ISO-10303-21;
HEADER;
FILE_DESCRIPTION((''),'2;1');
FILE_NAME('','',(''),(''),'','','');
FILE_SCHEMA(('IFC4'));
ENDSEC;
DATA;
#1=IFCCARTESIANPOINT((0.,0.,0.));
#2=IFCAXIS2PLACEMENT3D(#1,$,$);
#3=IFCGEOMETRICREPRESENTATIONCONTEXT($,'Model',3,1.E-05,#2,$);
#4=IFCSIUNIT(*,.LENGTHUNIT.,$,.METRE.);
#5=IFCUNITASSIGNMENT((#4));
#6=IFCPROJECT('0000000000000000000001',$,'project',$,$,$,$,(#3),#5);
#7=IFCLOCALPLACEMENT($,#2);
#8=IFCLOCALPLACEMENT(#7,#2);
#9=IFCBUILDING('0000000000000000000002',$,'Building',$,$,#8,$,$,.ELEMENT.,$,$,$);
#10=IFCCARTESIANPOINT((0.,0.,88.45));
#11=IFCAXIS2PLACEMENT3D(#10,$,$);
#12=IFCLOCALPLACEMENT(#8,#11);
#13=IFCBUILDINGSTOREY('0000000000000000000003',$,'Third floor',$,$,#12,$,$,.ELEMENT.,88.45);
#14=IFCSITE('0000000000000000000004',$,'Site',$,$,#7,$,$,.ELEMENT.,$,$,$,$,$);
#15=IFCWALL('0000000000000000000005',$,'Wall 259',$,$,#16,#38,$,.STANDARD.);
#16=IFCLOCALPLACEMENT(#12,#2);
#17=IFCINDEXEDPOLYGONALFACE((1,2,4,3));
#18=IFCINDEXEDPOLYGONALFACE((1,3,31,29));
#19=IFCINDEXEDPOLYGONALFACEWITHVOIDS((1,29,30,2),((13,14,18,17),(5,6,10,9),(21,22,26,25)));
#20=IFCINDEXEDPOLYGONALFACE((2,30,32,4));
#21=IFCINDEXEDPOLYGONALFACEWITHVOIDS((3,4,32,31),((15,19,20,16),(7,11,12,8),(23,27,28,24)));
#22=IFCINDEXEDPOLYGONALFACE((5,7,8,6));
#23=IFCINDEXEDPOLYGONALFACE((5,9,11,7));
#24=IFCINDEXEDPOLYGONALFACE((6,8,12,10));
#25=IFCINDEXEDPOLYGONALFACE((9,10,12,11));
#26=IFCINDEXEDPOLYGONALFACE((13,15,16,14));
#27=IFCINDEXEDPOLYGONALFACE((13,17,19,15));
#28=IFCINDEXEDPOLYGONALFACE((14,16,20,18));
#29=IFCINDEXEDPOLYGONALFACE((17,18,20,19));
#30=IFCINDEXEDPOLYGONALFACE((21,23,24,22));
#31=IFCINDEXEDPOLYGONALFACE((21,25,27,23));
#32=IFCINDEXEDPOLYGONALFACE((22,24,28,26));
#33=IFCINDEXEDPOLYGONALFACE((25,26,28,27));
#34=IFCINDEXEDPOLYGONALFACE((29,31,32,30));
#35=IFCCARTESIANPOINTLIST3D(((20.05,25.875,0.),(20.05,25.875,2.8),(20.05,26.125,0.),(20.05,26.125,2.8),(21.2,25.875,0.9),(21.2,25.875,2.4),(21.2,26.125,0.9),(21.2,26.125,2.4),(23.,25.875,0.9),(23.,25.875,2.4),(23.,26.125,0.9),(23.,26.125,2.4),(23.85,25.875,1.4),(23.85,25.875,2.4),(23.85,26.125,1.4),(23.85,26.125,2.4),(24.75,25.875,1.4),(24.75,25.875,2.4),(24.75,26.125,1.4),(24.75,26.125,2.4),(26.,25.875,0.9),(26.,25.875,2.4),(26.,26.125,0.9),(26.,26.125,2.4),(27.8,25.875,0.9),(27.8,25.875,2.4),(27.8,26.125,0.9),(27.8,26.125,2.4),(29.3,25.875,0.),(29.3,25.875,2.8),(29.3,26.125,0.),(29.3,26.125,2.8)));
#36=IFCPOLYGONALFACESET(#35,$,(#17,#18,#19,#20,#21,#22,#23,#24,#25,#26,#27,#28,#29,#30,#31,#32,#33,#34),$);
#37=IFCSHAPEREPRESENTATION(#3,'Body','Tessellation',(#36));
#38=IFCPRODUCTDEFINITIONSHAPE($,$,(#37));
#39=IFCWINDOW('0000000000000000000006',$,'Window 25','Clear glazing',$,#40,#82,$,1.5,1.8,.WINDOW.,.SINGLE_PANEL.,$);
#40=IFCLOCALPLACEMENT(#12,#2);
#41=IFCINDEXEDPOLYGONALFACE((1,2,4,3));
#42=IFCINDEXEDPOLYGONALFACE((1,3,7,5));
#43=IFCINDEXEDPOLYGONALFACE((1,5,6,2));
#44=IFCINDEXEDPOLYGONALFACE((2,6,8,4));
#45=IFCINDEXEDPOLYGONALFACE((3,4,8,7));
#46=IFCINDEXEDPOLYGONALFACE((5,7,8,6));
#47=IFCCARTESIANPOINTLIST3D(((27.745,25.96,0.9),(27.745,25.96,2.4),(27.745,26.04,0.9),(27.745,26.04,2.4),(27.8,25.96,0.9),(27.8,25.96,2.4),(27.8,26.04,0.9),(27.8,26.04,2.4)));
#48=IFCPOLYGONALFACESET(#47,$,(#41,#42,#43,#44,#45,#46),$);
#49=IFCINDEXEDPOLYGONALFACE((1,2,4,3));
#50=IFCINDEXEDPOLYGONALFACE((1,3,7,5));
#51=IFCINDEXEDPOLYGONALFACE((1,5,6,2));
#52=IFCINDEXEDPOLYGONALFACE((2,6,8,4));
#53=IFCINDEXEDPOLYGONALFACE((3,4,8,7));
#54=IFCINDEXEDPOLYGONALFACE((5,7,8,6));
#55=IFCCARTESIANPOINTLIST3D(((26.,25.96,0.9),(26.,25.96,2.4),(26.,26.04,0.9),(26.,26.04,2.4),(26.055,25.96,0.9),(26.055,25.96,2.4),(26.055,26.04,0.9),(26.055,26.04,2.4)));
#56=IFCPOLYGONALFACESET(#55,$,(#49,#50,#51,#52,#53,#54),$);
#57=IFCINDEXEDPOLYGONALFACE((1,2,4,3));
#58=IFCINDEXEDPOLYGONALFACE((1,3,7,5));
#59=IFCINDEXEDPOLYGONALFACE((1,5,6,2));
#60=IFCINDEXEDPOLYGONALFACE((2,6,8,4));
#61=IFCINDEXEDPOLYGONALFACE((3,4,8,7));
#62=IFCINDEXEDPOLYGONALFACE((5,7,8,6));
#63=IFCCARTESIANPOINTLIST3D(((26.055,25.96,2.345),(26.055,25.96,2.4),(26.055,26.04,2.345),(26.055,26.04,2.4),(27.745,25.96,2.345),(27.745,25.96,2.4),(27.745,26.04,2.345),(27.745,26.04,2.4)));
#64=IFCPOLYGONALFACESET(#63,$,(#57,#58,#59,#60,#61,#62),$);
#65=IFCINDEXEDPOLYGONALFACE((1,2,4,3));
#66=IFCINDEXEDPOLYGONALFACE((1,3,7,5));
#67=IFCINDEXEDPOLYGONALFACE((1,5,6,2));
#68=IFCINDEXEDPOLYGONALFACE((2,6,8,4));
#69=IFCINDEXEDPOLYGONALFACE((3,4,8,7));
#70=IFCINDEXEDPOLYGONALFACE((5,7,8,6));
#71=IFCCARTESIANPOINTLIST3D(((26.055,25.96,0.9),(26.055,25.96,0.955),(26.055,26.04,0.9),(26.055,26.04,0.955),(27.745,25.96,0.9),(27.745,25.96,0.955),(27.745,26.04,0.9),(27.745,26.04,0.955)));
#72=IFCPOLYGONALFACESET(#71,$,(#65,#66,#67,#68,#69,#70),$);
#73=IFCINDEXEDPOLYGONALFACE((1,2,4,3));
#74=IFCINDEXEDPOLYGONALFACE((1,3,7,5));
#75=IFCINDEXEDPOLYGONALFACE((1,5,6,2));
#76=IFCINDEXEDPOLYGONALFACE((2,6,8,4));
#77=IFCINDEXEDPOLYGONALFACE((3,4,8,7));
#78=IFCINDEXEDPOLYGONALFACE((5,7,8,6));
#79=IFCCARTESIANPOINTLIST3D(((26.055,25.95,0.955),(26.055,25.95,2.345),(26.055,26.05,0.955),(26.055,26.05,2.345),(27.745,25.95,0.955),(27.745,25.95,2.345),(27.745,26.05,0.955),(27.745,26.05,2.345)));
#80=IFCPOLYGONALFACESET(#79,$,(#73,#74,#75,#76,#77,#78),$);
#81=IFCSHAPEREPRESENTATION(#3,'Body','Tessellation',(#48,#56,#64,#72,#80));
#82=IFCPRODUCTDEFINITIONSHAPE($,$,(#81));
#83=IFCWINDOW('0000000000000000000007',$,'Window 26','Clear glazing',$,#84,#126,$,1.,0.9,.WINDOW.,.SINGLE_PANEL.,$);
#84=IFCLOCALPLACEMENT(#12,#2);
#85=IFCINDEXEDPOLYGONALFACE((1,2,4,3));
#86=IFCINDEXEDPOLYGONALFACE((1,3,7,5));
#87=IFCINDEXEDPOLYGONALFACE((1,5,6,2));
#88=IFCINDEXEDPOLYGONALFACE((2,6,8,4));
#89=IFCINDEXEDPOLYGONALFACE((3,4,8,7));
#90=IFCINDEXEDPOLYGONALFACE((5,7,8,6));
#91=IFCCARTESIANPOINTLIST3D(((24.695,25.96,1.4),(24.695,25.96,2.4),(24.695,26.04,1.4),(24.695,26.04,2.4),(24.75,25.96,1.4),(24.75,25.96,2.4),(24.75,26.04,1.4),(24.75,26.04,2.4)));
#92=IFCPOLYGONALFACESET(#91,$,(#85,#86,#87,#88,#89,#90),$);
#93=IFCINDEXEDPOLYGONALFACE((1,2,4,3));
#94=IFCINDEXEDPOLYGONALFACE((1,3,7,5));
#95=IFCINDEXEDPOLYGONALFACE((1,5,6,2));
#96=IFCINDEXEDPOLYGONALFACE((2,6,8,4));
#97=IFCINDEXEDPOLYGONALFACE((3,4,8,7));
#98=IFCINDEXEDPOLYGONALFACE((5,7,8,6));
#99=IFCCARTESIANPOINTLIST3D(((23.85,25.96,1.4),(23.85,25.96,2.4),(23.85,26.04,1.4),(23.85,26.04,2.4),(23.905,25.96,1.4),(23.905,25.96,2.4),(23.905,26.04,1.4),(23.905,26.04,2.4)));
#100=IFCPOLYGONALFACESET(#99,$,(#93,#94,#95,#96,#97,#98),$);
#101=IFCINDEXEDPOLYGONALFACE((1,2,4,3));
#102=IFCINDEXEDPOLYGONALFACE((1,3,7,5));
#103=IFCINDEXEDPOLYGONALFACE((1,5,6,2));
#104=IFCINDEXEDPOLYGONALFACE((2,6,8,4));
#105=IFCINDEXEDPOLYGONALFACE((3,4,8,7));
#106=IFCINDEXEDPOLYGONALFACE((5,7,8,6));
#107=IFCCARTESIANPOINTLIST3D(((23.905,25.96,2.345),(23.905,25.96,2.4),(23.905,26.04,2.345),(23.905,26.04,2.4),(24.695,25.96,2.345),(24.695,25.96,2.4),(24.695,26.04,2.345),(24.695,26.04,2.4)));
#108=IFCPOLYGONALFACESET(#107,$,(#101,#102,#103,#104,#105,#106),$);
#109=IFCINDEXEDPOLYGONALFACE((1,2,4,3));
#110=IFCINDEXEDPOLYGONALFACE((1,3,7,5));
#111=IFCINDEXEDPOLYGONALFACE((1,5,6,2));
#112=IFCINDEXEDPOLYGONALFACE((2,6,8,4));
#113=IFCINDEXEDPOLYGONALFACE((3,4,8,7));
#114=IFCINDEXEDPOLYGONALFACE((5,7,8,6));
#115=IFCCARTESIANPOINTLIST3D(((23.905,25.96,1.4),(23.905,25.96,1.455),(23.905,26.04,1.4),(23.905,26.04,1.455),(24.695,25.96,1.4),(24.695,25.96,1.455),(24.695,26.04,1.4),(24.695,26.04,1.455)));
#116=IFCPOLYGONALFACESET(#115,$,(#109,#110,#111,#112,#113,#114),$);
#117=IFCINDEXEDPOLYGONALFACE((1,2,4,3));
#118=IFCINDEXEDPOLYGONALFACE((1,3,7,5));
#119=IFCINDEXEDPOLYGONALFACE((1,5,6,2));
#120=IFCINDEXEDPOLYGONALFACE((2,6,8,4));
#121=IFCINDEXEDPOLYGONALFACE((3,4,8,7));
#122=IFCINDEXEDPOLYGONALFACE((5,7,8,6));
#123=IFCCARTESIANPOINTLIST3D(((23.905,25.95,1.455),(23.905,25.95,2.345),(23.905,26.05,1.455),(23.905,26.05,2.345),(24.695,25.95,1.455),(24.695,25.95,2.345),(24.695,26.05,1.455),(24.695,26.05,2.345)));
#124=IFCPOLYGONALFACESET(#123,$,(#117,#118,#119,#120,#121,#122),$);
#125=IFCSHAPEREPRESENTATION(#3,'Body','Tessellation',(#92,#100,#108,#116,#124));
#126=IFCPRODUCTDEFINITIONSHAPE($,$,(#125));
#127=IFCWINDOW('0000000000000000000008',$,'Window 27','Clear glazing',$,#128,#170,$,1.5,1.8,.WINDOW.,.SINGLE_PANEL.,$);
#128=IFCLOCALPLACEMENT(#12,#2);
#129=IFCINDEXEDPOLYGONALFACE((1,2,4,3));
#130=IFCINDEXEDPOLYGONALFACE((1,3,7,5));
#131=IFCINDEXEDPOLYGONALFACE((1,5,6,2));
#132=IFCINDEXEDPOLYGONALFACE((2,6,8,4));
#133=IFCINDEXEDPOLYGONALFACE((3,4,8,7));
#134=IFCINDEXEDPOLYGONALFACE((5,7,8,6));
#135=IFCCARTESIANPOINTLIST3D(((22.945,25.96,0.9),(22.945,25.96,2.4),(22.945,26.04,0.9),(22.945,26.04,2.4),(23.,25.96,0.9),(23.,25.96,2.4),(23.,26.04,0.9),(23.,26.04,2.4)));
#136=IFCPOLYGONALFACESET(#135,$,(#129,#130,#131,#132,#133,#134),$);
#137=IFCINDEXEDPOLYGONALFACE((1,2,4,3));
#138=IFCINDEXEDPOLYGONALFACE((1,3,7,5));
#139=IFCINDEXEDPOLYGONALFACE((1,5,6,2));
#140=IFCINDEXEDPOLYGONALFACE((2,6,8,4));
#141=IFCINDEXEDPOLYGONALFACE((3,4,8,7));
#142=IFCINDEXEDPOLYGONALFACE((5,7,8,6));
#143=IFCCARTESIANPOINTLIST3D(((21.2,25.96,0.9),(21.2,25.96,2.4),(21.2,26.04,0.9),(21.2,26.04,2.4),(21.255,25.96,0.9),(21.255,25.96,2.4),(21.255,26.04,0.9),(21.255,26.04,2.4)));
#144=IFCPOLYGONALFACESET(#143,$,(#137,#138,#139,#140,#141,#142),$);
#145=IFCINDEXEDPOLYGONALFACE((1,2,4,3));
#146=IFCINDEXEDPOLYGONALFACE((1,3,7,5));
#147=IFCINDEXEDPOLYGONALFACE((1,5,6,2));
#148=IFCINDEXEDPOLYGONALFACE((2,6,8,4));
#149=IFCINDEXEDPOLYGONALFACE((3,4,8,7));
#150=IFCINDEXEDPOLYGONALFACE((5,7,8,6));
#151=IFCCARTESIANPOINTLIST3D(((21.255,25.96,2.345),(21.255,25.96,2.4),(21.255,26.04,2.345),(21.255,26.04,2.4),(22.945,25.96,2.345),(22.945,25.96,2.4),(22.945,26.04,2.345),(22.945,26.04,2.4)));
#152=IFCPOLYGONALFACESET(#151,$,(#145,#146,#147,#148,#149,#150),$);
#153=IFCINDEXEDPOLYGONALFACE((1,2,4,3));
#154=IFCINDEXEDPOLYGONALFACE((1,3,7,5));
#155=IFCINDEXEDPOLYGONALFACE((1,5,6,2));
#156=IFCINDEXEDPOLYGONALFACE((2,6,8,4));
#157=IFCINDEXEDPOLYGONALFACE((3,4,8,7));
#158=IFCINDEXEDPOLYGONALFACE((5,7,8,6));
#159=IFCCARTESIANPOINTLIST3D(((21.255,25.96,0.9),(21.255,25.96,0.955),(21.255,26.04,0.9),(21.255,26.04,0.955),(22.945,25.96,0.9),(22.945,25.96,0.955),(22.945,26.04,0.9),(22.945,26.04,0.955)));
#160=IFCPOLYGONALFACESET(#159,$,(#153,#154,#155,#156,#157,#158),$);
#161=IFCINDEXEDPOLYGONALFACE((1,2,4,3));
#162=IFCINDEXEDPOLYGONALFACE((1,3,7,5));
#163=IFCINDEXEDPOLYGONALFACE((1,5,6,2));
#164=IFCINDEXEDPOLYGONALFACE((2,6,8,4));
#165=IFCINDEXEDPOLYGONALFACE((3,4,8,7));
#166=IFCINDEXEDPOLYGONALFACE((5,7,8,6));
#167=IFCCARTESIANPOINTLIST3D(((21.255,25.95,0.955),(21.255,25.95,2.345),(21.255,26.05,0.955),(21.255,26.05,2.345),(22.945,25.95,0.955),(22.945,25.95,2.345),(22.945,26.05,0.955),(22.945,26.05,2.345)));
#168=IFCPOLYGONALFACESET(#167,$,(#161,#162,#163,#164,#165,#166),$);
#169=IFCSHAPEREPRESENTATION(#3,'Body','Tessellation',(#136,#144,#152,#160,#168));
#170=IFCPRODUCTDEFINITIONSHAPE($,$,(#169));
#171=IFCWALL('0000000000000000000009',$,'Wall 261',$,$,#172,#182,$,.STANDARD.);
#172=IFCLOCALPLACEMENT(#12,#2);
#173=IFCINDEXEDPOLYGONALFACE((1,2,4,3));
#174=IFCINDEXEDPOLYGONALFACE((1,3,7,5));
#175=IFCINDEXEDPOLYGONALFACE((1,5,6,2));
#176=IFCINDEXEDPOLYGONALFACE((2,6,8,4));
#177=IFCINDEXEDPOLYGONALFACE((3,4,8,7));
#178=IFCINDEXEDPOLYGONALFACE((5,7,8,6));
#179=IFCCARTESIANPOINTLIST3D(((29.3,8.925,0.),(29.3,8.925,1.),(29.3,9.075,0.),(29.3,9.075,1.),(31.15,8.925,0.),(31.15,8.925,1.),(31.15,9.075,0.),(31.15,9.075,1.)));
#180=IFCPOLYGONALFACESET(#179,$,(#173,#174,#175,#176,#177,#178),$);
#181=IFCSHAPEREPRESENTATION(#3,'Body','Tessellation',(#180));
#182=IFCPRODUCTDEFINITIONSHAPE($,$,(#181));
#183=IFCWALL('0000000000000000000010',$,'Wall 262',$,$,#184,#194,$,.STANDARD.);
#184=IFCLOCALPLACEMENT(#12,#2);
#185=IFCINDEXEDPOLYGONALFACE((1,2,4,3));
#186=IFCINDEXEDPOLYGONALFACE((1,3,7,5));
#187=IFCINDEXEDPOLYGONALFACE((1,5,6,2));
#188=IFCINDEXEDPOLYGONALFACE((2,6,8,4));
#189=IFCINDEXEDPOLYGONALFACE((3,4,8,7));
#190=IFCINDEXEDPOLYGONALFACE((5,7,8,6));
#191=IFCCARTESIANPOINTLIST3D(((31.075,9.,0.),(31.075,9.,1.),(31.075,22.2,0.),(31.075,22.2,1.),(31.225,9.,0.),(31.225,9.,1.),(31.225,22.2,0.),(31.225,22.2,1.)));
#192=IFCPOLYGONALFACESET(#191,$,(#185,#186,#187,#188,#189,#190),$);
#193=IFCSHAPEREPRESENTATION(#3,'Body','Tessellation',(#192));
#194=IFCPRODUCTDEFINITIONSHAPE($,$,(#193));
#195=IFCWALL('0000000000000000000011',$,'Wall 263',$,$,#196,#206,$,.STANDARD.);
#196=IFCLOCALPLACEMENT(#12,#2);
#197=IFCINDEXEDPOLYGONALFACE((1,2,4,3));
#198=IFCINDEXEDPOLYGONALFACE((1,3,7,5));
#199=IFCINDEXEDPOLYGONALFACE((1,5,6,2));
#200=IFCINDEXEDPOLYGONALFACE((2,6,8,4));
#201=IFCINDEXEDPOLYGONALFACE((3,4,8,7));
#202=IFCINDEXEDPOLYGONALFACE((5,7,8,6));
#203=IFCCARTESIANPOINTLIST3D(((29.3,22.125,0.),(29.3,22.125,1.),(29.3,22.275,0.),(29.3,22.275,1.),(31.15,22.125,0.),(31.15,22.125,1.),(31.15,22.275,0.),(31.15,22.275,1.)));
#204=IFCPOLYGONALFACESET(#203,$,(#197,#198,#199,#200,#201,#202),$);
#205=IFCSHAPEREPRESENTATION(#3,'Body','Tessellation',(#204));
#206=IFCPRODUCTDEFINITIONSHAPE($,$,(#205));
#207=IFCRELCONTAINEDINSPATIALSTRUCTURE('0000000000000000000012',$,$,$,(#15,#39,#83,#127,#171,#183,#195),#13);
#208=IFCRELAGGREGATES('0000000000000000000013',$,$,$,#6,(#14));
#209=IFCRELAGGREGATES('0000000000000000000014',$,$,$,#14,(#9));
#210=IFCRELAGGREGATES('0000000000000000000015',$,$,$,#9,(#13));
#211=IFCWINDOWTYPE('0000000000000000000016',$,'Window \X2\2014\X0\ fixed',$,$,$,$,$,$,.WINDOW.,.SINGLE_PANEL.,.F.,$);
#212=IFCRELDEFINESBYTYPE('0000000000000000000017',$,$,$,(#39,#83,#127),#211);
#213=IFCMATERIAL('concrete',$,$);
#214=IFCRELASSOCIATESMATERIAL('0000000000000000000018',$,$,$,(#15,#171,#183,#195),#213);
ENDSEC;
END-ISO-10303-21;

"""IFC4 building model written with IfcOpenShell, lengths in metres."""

from ifc_helpers import new_model, si_unit, frame, frame_2d, origin, place, context, project, spatial, rectangle, extrude, material, type_object, element, fill, save


model = new_model("IFC4")

# Units and contexts
model_context = context("Model", 3, precision=1e-05, world=origin())
ifc_project = project(units=[si_unit("LENGTHUNIT", "METRE")], contexts=[model_context])

# Site, building, storey
site_placement = place(None, origin())
site = spatial("IfcSite", under=ifc_project, at=site_placement, Name="Site", CompositionType="ELEMENT")
building_placement = place(site_placement, origin())
building = spatial("IfcBuilding", under=site, at=building_placement, Name="Building", CompositionType="ELEMENT")
storey_placement = place(building_placement, frame((0.0, 0.0, 88.45)))
storey = spatial("IfcBuildingStorey", under=building, at=storey_placement, Name="Third floor", CompositionType="ELEMENT", Elevation=88.45)

# Shared definitions
ifc_material = material(Name="concrete")

# Shared definitions
window_type = type_object("IfcWindowType", Name="Window — fixed", ParameterTakesPrecedence=False, PartitioningType="SINGLE_PANEL", PredefinedType="WINDOW")

# Wall, openings, windows
wall_1_placement = place(storey_placement, frame((29.3, 26.0, 0.0), z_axis=(0.0, 0.0, 1.0), x_axis=(-1.0, 0.0, 0.0)))
wall_1 = element("IfcWall", 1, at=wall_1_placement, inside=storey, material=ifc_material, Name="Wall 259", PredefinedType="STANDARD", context=model_context, shape_type="SweptSolid", body=[
    extrude(rectangle(XDim=9.25, YDim=0.25, at=frame_2d((4.625, 0.0))), origin(), (0.0, 0.0, 1.0), 2.8),
])
opening_1_placement = place(storey_placement, frame((27.8, 26.0, 0.9), z_axis=(0.0, 0.0, 1.0), x_axis=(-1.0, 0.0, 0.0)))
opening_1 = element("IfcOpeningElement", 2, at=opening_1_placement, cuts=wall_1, PredefinedType="OPENING", context=model_context, shape_type="SweptSolid", body=[
    extrude(rectangle(XDim=1.8, YDim=0.31, at=frame_2d((0.9, 0.0))), origin(), (0.0, 0.0, 1.0), 1.5),
])
opening_2_placement = place(storey_placement, frame((24.75, 26.0, 1.4), z_axis=(0.0, 0.0, 1.0), x_axis=(-1.0, 0.0, 0.0)))
opening_2 = element("IfcOpeningElement", 3, at=opening_2_placement, cuts=wall_1, PredefinedType="OPENING", context=model_context, shape_type="SweptSolid", body=[
    extrude(rectangle(XDim=0.9, YDim=0.31, at=frame_2d((0.45, 0.0))), origin(), (0.0, 0.0, 1.0), 1.0),
])
opening_3_placement = place(storey_placement, frame((23.0, 26.0, 0.9), z_axis=(0.0, 0.0, 1.0), x_axis=(-1.0, 0.0, 0.0)))
opening_3 = element("IfcOpeningElement", 4, at=opening_3_placement, cuts=wall_1, PredefinedType="OPENING", context=model_context, shape_type="SweptSolid", body=[
    extrude(rectangle(XDim=1.8, YDim=0.31, at=frame_2d((0.9, 0.0))), origin(), (0.0, 0.0, 1.0), 1.5),
])
window_1_placement = place(storey_placement, frame((27.8, 26.0, 0.9), z_axis=(0.0, 0.0, 1.0), x_axis=(-1.0, 0.0, 0.0)))
window_1 = element("IfcWindow", 5, at=window_1_placement, inside=storey, type_object=window_type, Name="Window 25", Description="Clear glazing", OverallHeight=1.5, OverallWidth=1.8, PartitioningType="SINGLE_PANEL", PredefinedType="WINDOW", context=model_context, shape_type="SweptSolid", body=[
    extrude(rectangle(XDim=0.055, YDim=0.08, at=frame_2d((0.0275, 0.0))), origin(), (0.0, 0.0, 1.0), 1.5),
    extrude(rectangle(XDim=0.055, YDim=0.08, at=frame_2d((1.7725, 0.0))), origin(), (0.0, 0.0, 1.0), 1.5),
    extrude(rectangle(XDim=1.69, YDim=0.08, at=frame_2d((0.9, 0.0))), frame((0.0, 0.0, 1.445)), (0.0, 0.0, 1.0), 0.055),
    extrude(rectangle(XDim=1.69, YDim=0.08, at=frame_2d((0.9, 0.0))), origin(), (0.0, 0.0, 1.0), 0.055),
    extrude(rectangle(XDim=1.69, YDim=0.1, at=frame_2d((0.9, 0.0))), frame((0.0, 0.0, 0.055)), (0.0, 0.0, 1.0), 1.39),
])
fill(opening_1, window_1)
window_2_placement = place(storey_placement, frame((24.75, 26.0, 1.4), z_axis=(0.0, 0.0, 1.0), x_axis=(-1.0, 0.0, 0.0)))
window_2 = element("IfcWindow", 6, at=window_2_placement, inside=storey, type_object=window_type, Name="Window 26", Description="Clear glazing", OverallHeight=1.0, OverallWidth=0.9, PartitioningType="SINGLE_PANEL", PredefinedType="WINDOW", context=model_context, shape_type="SweptSolid", body=[
    extrude(rectangle(XDim=0.055, YDim=0.08, at=frame_2d((0.0275, 0.0))), origin(), (0.0, 0.0, 1.0), 1.0),
    extrude(rectangle(XDim=0.055, YDim=0.08, at=frame_2d((0.8725, 0.0))), origin(), (0.0, 0.0, 1.0), 1.0),
    extrude(rectangle(XDim=0.79, YDim=0.08, at=frame_2d((0.45, 0.0))), frame((0.0, 0.0, 0.945)), (0.0, 0.0, 1.0), 0.055),
    extrude(rectangle(XDim=0.79, YDim=0.08, at=frame_2d((0.45, 0.0))), origin(), (0.0, 0.0, 1.0), 0.055),
    extrude(rectangle(XDim=0.79, YDim=0.1, at=frame_2d((0.45, 0.0))), frame((0.0, 0.0, 0.055)), (0.0, 0.0, 1.0), 0.89),
])
fill(opening_2, window_2)
window_3_placement = place(storey_placement, frame((23.0, 26.0, 0.9), z_axis=(0.0, 0.0, 1.0), x_axis=(-1.0, 0.0, 0.0)))
window_3 = element("IfcWindow", 7, at=window_3_placement, inside=storey, type_object=window_type, Name="Window 27", Description="Clear glazing", OverallHeight=1.5, OverallWidth=1.8, PartitioningType="SINGLE_PANEL", PredefinedType="WINDOW", context=model_context, shape_type="SweptSolid", body=[
    extrude(rectangle(XDim=0.055, YDim=0.08, at=frame_2d((0.0275, 0.0))), origin(), (0.0, 0.0, 1.0), 1.5),
    extrude(rectangle(XDim=0.055, YDim=0.08, at=frame_2d((1.7725, 0.0))), origin(), (0.0, 0.0, 1.0), 1.5),
    extrude(rectangle(XDim=1.69, YDim=0.08, at=frame_2d((0.9, 0.0))), frame((0.0, 0.0, 1.445)), (0.0, 0.0, 1.0), 0.055),
    extrude(rectangle(XDim=1.69, YDim=0.08, at=frame_2d((0.9, 0.0))), origin(), (0.0, 0.0, 1.0), 0.055),
    extrude(rectangle(XDim=1.69, YDim=0.1, at=frame_2d((0.9, 0.0))), frame((0.0, 0.0, 0.055)), (0.0, 0.0, 1.0), 1.39),
])
fill(opening_3, window_3)

# Walls
wall_2_placement = place(storey_placement, frame((29.3, 9.0, 0.0), z_axis=(0.0, 0.0, 1.0), x_axis=(1.0, 0.0, 0.0)))
element("IfcWall", 8, at=wall_2_placement, inside=storey, material=ifc_material, Name="Wall 261", PredefinedType="STANDARD", context=model_context, shape_type="SweptSolid", body=[
    extrude(rectangle(XDim=1.85, YDim=0.15, at=frame_2d((0.925, 0.0))), origin(), (0.0, 0.0, 1.0), 1.0),
])
wall_3_placement = place(storey_placement, frame((31.15, 9.0, 0.0), z_axis=(0.0, 0.0, 1.0), x_axis=(0.0, 1.0, 0.0)))
element("IfcWall", 9, at=wall_3_placement, inside=storey, material=ifc_material, Name="Wall 262", PredefinedType="STANDARD", context=model_context, shape_type="SweptSolid", body=[
    extrude(rectangle(XDim=13.2, YDim=0.15, at=frame_2d((6.6, 0.0))), origin(), (0.0, 0.0, 1.0), 1.0),
])
wall_4_placement = place(storey_placement, frame((31.15, 22.2, 0.0), z_axis=(0.0, 0.0, 1.0), x_axis=(-1.0, 0.0, 0.0)))
element("IfcWall", 10, at=wall_4_placement, inside=storey, material=ifc_material, Name="Wall 263", PredefinedType="STANDARD", context=model_context, shape_type="SweptSolid", body=[
    extrude(rectangle(XDim=1.85, YDim=0.15, at=frame_2d((0.925, 0.0))), origin(), (0.0, 0.0, 1.0), 1.0),
])

save(model, "model.ifc")
